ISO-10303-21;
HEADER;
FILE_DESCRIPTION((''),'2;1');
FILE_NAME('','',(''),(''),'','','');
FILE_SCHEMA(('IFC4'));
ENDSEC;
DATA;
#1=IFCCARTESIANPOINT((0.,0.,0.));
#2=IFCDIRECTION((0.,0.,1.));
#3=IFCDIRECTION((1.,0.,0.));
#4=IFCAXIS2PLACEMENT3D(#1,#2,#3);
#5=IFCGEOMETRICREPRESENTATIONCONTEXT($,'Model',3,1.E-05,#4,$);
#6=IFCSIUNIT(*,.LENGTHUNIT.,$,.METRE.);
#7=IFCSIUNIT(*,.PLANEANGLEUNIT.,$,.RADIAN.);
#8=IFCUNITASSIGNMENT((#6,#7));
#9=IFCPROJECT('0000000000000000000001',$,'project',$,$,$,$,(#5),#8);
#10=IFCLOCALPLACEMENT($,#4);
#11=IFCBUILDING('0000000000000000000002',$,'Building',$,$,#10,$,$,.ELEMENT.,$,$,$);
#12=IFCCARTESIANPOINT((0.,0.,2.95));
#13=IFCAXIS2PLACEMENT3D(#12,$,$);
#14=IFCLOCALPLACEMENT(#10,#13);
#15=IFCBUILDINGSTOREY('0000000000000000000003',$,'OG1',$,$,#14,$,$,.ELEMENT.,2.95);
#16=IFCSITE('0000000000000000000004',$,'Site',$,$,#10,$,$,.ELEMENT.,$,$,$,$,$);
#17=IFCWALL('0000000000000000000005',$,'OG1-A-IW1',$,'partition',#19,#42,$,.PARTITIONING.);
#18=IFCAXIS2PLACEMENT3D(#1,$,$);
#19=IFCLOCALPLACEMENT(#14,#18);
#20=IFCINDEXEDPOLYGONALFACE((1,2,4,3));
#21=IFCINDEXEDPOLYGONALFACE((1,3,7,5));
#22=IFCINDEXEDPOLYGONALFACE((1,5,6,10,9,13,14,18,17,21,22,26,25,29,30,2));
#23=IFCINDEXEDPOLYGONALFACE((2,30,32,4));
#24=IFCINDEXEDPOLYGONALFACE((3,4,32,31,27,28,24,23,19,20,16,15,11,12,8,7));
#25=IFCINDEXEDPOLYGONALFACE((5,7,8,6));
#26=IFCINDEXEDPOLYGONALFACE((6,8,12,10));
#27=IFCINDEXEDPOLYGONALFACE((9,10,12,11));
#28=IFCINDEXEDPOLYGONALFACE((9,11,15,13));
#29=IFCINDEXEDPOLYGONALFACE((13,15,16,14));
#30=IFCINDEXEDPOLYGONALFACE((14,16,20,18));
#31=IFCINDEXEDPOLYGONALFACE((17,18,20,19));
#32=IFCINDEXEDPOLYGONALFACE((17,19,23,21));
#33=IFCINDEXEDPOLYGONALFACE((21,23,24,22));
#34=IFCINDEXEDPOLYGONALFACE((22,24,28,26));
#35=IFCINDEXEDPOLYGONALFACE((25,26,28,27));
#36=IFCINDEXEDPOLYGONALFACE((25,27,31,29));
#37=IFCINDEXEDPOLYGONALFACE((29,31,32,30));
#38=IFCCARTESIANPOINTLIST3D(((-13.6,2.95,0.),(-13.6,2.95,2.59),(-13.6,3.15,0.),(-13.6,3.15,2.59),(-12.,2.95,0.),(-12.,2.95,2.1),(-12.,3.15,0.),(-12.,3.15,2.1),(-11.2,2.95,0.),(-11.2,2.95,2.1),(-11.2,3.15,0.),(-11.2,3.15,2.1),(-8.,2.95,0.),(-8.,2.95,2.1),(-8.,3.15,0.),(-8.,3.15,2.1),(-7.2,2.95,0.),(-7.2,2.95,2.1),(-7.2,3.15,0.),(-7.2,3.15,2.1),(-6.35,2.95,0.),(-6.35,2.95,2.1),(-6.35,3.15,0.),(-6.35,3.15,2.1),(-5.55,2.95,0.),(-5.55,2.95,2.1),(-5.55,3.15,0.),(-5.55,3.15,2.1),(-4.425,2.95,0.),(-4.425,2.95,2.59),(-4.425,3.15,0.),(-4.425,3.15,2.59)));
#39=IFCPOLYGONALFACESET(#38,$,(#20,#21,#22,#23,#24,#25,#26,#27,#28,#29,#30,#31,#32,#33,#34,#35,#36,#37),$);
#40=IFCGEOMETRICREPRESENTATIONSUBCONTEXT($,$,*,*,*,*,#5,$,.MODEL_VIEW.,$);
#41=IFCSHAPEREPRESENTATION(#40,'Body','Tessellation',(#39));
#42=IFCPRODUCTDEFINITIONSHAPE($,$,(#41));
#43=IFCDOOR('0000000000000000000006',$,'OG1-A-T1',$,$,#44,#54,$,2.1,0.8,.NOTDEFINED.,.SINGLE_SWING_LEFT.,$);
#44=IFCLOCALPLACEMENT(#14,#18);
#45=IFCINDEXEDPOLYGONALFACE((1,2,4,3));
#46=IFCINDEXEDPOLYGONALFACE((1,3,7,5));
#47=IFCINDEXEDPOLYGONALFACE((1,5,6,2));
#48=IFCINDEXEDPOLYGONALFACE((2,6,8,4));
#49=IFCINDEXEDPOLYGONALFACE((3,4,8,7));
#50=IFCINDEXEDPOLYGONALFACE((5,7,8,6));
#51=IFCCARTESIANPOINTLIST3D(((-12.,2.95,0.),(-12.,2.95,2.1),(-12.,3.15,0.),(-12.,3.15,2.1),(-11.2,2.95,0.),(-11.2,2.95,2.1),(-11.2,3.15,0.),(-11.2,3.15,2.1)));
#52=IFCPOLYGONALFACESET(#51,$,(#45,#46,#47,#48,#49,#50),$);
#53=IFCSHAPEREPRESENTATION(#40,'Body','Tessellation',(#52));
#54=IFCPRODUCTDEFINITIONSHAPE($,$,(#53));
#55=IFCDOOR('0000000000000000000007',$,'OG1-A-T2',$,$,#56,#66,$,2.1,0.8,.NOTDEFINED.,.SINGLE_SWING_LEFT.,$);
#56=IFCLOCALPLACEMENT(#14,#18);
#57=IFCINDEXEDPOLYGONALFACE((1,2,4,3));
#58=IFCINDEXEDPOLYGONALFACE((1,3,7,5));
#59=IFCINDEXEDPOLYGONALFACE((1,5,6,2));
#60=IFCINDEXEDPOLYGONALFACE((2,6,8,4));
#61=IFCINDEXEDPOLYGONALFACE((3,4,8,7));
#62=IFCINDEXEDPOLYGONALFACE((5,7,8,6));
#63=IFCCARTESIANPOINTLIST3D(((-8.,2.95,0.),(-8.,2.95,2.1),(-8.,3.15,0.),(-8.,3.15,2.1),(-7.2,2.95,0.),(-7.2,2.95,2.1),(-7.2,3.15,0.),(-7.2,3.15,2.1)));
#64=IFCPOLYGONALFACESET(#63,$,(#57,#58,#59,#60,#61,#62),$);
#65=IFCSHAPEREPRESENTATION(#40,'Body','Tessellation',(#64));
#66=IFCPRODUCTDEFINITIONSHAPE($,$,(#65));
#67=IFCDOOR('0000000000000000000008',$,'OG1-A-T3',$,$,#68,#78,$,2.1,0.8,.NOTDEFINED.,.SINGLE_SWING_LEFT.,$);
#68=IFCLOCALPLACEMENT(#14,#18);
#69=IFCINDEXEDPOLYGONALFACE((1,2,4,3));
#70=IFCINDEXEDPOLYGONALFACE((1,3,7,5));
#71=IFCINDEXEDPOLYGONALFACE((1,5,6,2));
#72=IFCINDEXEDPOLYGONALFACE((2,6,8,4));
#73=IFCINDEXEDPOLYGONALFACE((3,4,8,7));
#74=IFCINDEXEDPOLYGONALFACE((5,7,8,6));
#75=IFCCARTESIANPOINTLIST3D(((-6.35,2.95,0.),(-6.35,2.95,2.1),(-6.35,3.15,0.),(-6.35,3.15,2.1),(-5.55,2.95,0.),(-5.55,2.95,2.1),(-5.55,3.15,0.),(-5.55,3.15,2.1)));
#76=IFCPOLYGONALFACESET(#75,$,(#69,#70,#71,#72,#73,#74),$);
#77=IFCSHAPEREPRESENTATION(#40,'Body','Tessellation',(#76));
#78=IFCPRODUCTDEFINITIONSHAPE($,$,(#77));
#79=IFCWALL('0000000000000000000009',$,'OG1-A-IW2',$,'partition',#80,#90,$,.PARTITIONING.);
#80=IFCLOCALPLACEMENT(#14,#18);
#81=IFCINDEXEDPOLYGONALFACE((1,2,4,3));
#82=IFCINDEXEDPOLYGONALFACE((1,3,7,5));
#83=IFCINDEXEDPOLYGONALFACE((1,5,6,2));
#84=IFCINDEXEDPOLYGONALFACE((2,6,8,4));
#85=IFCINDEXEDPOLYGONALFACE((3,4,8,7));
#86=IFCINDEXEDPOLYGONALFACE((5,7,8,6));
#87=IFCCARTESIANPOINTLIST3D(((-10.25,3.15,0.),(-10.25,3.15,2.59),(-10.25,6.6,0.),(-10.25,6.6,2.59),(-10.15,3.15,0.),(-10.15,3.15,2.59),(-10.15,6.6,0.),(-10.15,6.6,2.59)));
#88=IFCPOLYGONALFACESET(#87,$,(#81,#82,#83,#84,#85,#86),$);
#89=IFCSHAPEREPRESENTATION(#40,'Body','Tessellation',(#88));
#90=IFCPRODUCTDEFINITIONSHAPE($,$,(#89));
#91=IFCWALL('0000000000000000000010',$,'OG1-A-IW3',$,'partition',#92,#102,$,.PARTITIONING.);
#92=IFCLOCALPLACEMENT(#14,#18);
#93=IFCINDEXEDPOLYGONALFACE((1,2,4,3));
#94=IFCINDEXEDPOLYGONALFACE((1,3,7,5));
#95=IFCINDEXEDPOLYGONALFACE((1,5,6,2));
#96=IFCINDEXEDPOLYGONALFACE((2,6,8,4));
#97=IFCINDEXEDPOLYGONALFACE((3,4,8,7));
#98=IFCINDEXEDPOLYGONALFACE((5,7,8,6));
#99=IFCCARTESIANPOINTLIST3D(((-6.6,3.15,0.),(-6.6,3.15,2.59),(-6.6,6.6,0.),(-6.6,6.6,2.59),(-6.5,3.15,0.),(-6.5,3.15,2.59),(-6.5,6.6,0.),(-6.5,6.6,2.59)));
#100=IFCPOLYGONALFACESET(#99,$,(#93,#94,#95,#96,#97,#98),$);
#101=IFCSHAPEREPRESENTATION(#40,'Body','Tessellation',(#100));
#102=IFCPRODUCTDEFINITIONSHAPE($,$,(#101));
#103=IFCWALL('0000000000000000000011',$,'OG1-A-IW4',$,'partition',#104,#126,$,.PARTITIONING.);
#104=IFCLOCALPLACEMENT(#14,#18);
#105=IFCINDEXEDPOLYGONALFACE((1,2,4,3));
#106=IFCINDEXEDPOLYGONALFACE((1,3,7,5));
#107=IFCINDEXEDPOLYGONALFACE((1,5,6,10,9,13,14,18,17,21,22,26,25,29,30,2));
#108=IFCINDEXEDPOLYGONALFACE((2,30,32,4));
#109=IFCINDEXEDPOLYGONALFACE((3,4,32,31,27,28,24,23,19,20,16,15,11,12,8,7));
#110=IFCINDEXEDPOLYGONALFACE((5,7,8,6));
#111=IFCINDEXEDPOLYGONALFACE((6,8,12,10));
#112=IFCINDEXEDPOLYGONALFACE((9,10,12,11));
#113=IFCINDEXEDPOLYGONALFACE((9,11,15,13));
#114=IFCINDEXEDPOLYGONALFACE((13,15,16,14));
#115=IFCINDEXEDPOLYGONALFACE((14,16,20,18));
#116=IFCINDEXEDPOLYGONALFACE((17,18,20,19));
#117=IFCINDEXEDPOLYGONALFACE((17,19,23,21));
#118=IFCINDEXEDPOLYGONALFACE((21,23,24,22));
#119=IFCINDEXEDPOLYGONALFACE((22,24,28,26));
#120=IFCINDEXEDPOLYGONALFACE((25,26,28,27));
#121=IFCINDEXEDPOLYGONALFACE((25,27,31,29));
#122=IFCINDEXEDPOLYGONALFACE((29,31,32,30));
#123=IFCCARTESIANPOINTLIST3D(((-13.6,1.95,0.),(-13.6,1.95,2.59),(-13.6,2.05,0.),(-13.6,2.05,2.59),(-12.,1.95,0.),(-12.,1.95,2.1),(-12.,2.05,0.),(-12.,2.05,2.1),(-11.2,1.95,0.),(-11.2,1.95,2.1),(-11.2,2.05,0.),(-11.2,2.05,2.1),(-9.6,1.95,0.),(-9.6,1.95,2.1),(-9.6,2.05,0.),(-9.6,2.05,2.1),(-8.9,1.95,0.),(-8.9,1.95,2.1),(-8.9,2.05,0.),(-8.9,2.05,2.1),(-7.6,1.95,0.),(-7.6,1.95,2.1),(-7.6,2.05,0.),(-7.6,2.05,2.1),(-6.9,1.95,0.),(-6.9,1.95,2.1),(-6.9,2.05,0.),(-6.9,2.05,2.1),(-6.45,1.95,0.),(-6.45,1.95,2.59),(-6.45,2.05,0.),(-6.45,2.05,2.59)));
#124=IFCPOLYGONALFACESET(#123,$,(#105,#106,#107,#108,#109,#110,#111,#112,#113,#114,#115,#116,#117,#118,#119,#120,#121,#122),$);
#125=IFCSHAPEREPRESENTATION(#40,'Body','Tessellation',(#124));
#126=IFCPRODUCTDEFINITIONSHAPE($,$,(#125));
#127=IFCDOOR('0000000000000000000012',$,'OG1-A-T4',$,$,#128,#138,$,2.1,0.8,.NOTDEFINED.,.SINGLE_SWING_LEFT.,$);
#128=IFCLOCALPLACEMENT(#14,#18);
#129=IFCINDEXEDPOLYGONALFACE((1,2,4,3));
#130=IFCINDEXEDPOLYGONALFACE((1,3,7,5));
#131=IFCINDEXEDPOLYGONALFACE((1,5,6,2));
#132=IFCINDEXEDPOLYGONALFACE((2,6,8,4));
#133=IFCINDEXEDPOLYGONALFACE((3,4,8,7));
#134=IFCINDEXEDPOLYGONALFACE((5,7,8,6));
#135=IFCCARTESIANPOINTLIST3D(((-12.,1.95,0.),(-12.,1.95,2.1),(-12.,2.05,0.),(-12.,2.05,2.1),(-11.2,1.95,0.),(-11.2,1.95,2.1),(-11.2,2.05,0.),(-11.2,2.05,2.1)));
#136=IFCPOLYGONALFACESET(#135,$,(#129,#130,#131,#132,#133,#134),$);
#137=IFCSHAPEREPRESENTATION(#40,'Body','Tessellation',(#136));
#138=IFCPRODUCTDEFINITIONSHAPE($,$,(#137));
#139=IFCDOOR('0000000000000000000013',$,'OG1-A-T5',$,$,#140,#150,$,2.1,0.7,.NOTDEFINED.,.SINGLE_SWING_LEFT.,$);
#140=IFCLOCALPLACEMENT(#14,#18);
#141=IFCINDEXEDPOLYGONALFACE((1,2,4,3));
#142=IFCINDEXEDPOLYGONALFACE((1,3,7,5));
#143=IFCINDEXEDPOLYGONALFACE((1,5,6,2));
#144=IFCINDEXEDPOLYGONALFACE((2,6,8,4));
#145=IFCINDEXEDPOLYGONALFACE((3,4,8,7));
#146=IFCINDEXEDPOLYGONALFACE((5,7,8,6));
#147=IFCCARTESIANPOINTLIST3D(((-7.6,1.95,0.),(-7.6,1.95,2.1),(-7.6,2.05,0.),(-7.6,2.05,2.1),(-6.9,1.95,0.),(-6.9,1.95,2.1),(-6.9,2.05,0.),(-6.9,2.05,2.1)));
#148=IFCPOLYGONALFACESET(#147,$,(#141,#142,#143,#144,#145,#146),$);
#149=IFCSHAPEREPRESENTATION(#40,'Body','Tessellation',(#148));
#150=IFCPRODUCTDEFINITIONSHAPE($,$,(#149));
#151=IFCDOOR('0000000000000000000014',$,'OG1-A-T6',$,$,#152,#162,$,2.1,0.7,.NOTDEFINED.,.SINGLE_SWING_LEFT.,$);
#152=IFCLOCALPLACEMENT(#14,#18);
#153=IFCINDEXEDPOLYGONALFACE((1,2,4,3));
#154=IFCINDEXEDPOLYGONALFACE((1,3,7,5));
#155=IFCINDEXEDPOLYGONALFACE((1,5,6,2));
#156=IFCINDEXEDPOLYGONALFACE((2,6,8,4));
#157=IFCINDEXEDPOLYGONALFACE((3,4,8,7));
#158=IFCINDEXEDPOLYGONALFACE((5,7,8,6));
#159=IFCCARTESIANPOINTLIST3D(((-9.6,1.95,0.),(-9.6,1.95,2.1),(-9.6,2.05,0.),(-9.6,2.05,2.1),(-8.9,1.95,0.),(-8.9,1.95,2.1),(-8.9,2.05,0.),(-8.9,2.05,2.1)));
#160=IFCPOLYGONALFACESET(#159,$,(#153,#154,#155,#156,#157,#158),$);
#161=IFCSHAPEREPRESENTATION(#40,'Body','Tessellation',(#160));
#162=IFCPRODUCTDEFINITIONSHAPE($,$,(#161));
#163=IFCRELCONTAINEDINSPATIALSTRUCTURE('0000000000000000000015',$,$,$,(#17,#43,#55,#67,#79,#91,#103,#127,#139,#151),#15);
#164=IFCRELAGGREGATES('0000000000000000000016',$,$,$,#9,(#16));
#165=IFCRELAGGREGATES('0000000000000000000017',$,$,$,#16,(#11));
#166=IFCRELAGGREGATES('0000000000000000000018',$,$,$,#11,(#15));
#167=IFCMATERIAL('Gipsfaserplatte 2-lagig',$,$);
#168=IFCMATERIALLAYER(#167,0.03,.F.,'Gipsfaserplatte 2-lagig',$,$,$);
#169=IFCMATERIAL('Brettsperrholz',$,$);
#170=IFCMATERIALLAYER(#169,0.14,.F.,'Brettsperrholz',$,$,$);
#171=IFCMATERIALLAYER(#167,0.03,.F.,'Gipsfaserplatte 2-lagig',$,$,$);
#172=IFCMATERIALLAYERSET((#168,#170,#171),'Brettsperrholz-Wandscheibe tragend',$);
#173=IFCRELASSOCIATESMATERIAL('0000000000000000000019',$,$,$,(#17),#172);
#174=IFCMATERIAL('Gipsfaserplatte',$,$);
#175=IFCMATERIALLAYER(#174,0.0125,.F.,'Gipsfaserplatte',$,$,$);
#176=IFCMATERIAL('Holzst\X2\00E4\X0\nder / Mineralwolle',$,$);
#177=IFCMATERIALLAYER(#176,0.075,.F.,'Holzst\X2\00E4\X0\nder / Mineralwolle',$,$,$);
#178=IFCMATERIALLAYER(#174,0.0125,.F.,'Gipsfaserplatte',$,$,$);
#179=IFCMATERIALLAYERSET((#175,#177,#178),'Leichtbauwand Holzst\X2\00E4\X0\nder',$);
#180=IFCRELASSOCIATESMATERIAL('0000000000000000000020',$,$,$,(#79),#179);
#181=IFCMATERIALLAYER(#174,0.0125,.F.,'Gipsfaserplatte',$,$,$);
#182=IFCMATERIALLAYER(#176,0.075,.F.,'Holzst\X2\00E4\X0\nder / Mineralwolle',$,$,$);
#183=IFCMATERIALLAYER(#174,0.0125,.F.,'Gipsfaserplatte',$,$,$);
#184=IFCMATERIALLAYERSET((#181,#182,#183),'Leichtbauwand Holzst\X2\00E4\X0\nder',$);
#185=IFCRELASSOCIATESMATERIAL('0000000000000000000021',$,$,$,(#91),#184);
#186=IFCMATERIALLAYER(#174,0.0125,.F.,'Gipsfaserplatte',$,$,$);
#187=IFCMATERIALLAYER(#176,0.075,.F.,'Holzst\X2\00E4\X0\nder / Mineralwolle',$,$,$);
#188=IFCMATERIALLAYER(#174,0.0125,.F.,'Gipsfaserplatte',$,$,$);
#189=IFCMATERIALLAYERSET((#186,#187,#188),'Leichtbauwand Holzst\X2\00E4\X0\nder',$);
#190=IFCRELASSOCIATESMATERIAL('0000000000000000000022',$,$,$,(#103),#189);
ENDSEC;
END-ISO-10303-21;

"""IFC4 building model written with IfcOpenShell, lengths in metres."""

from ifc_helpers import new_model, si_unit, frame, frame_2d, origin, origin_with_axes, place, context, subcontext, project, spatial, rectangle, extrude, material, layer, layer_set, element, fill, save


model = new_model("IFC4")

# Units and contexts
model_context = context("Model", 3, precision=1e-05, world=origin_with_axes())
sub_context = subcontext(model_context, None, None, "MODEL_VIEW")
ifc_project = project(units=[si_unit("LENGTHUNIT", "METRE"), si_unit("PLANEANGLEUNIT", "RADIAN")], contexts=[model_context])

# Site, building, storey
placement = place(None, origin_with_axes())
site = spatial("IfcSite", under=ifc_project, at=placement, Name="Site", CompositionType="ELEMENT")
building = spatial("IfcBuilding", under=site, at=placement, Name="Building", CompositionType="ELEMENT")
storey_placement = place(placement, frame((0.0, 0.0, 2.95)))
storey = spatial("IfcBuildingStorey", under=building, at=storey_placement, Name="OG1", CompositionType="ELEMENT", Elevation=2.95)

# Shared definitions
ifc_material_1 = material(Name="Gipsfaserplatte")

# Wall, openings, doors
ifc_material_2 = material(Name="Gipsfaserplatte 2-lagig")
ifc_layer_1 = layer(ifc_material_2, 0.03, ventilated=False, Name="Gipsfaserplatte 2-lagig")
ifc_material_3 = material(Name="Brettsperrholz")
ifc_layer_2 = layer(ifc_material_3, 0.14, ventilated=False, Name="Brettsperrholz")
ifc_layer_3 = layer(ifc_material_2, 0.03, ventilated=False, Name="Gipsfaserplatte 2-lagig")
ifc_layer_set_1 = layer_set([ifc_layer_1, ifc_layer_2, ifc_layer_3], Name="Brettsperrholz-Wandscheibe tragend")
wall_1_placement = place(storey_placement, frame((-13.6, 3.05, 0.0), z_axis=(0.0, 0.0, 1.0), x_axis=(1.0, 0.0, 0.0)))
wall_1 = element("IfcWall", 1, at=wall_1_placement, inside=storey, material=ifc_layer_set_1, Name="OG1-A-IW1", ObjectType="partition", PredefinedType="PARTITIONING", context=sub_context, shape_type="SweptSolid", body=[
    extrude(rectangle(XDim=9.175, YDim=0.2, at=frame_2d((4.5875, 0.0))), origin(), (0.0, 0.0, 1.0), 2.59),
])
opening_1_placement = place(wall_1_placement, frame((2.0, 0.15, 0.0), z_axis=(0.0, -1.0, 0.0), x_axis=(1.0, 0.0, 0.0)))
opening_1 = element("IfcOpeningElement", 2, at=opening_1_placement, cuts=wall_1, PredefinedType="OPENING", context=sub_context, shape_type="SweptSolid", body=[
    extrude(rectangle(XDim=0.8, YDim=2.1, at=frame_2d((0.0, 1.05))), origin(), (0.0, 0.0, 1.0), 0.3),
])
opening_2_placement = place(wall_1_placement, frame((6.0, 0.15, 0.0), z_axis=(0.0, -1.0, 0.0), x_axis=(1.0, 0.0, 0.0)))
opening_2 = element("IfcOpeningElement", 3, at=opening_2_placement, cuts=wall_1, PredefinedType="OPENING", context=sub_context, shape_type="SweptSolid", body=[
    extrude(rectangle(XDim=0.8, YDim=2.1, at=frame_2d((0.0, 1.05))), origin(), (0.0, 0.0, 1.0), 0.3),
])
opening_3_placement = place(wall_1_placement, frame((7.65, 0.15, 0.0), z_axis=(0.0, -1.0, 0.0), x_axis=(1.0, 0.0, 0.0)))
opening_3 = element("IfcOpeningElement", 4, at=opening_3_placement, cuts=wall_1, PredefinedType="OPENING", context=sub_context, shape_type="SweptSolid", body=[
    extrude(rectangle(XDim=0.8, YDim=2.1, at=frame_2d((0.0, 1.05))), origin(), (0.0, 0.0, 1.0), 0.3),
])
door_1_placement = place(wall_1_placement, frame((2.0, 0.1, 0.0), z_axis=(0.0, -1.0, 0.0), x_axis=(1.0, 0.0, 0.0)))
door_1 = element("IfcDoor", 5, at=door_1_placement, inside=storey, Name="OG1-A-T1", OperationType="SINGLE_SWING_LEFT", OverallHeight=2.1, OverallWidth=0.8, PredefinedType="NOTDEFINED", context=sub_context, shape_type="SweptSolid", body=[
    extrude(rectangle(XDim=0.8, YDim=2.1, at=frame_2d((0.0, 1.05))), origin(), (0.0, 0.0, 1.0), 0.2),
])
fill(opening_1, door_1)
door_2_placement = place(wall_1_placement, frame((6.0, 0.1, 0.0), z_axis=(0.0, -1.0, 0.0), x_axis=(1.0, 0.0, 0.0)))
door_2 = element("IfcDoor", 6, at=door_2_placement, inside=storey, Name="OG1-A-T2", OperationType="SINGLE_SWING_LEFT", OverallHeight=2.1, OverallWidth=0.8, PredefinedType="NOTDEFINED", context=sub_context, shape_type="SweptSolid", body=[
    extrude(rectangle(XDim=0.8, YDim=2.1, at=frame_2d((0.0, 1.05))), origin(), (0.0, 0.0, 1.0), 0.2),
])
fill(opening_2, door_2)
door_3_placement = place(wall_1_placement, frame((7.65, 0.1, 0.0), z_axis=(0.0, -1.0, 0.0), x_axis=(1.0, 0.0, 0.0)))
door_3 = element("IfcDoor", 7, at=door_3_placement, inside=storey, Name="OG1-A-T3", OperationType="SINGLE_SWING_LEFT", OverallHeight=2.1, OverallWidth=0.8, PredefinedType="NOTDEFINED", context=sub_context, shape_type="SweptSolid", body=[
    extrude(rectangle(XDim=0.8, YDim=2.1, at=frame_2d((0.0, 1.05))), origin(), (0.0, 0.0, 1.0), 0.2),
])
fill(opening_3, door_3)

# Walls
ifc_layer_4 = layer(ifc_material_1, 0.0125, ventilated=False, Name="Gipsfaserplatte")
ifc_material_4 = material(Name="Holzständer / Mineralwolle")
ifc_layer_5 = layer(ifc_material_4, 0.075, ventilated=False, Name="Holzständer / Mineralwolle")
ifc_layer_6 = layer(ifc_material_1, 0.0125, ventilated=False, Name="Gipsfaserplatte")
ifc_layer_set_2 = layer_set([ifc_layer_4, ifc_layer_5, ifc_layer_6], Name="Leichtbauwand Holzständer")
wall_2_placement = place(storey_placement, frame((-10.2, 3.15, 0.0), z_axis=(0.0, 0.0, 1.0), x_axis=(0.0, 1.0, 0.0)))
element("IfcWall", 8, at=wall_2_placement, inside=storey, material=ifc_layer_set_2, Name="OG1-A-IW2", ObjectType="partition", PredefinedType="PARTITIONING", context=sub_context, shape_type="SweptSolid", body=[
    extrude(rectangle(XDim=3.45, YDim=0.1, at=frame_2d((1.725, 0.0))), origin(), (0.0, 0.0, 1.0), 2.59),
])
ifc_layer_7 = layer(ifc_material_1, 0.0125, ventilated=False, Name="Gipsfaserplatte")
ifc_layer_8 = layer(ifc_material_4, 0.075, ventilated=False, Name="Holzständer / Mineralwolle")
ifc_layer_9 = layer(ifc_material_1, 0.0125, ventilated=False, Name="Gipsfaserplatte")
ifc_layer_set_3 = layer_set([ifc_layer_7, ifc_layer_8, ifc_layer_9], Name="Leichtbauwand Holzständer")
wall_3_placement = place(storey_placement, frame((-6.55, 3.15, 0.0), z_axis=(0.0, 0.0, 1.0), x_axis=(0.0, 1.0, 0.0)))
element("IfcWall", 9, at=wall_3_placement, inside=storey, material=ifc_layer_set_3, Name="OG1-A-IW3", ObjectType="partition", PredefinedType="PARTITIONING", context=sub_context, shape_type="SweptSolid", body=[
    extrude(rectangle(XDim=3.45, YDim=0.1, at=frame_2d((1.725, 0.0))), origin(), (0.0, 0.0, 1.0), 2.59),
])

# Wall, openings, doors
ifc_layer_10 = layer(ifc_material_1, 0.0125, ventilated=False, Name="Gipsfaserplatte")
ifc_layer_11 = layer(ifc_material_4, 0.075, ventilated=False, Name="Holzständer / Mineralwolle")
ifc_layer_12 = layer(ifc_material_1, 0.0125, ventilated=False, Name="Gipsfaserplatte")
ifc_layer_set_4 = layer_set([ifc_layer_10, ifc_layer_11, ifc_layer_12], Name="Leichtbauwand Holzständer")
wall_4_placement = place(storey_placement, frame((-13.6, 2.0, 0.0), z_axis=(0.0, 0.0, 1.0), x_axis=(1.0, 0.0, 0.0)))
wall_4 = element("IfcWall", 10, at=wall_4_placement, inside=storey, material=ifc_layer_set_4, Name="OG1-A-IW4", ObjectType="partition", PredefinedType="PARTITIONING", context=sub_context, shape_type="SweptSolid", body=[
    extrude(rectangle(XDim=7.15, YDim=0.1, at=frame_2d((3.575, 0.0))), origin(), (0.0, 0.0, 1.0), 2.59),
])
opening_4_placement = place(wall_4_placement, frame((2.0, 0.1, 0.0), z_axis=(0.0, -1.0, 0.0), x_axis=(1.0, 0.0, 0.0)))
opening_4 = element("IfcOpeningElement", 11, at=opening_4_placement, cuts=wall_4, PredefinedType="OPENING", context=sub_context, shape_type="SweptSolid", body=[
    extrude(rectangle(XDim=0.8, YDim=2.1, at=frame_2d((0.0, 1.05))), origin(), (0.0, 0.0, 1.0), 0.2),
])
opening_5_placement = place(wall_4_placement, frame((6.35, 0.1, 0.0), z_axis=(0.0, -1.0, 0.0), x_axis=(1.0, 0.0, 0.0)))
opening_5 = element("IfcOpeningElement", 12, at=opening_5_placement, cuts=wall_4, PredefinedType="OPENING", context=sub_context, shape_type="SweptSolid", body=[
    extrude(rectangle(XDim=0.7, YDim=2.1, at=frame_2d((0.0, 1.05))), origin(), (0.0, 0.0, 1.0), 0.2),
])
opening_6_placement = place(wall_4_placement, frame((4.35, 0.1, 0.0), z_axis=(0.0, -1.0, 0.0), x_axis=(1.0, 0.0, 0.0)))
opening_6 = element("IfcOpeningElement", 13, at=opening_6_placement, cuts=wall_4, PredefinedType="OPENING", context=sub_context, shape_type="SweptSolid", body=[
    extrude(rectangle(XDim=0.7, YDim=2.1, at=frame_2d((0.0, 1.05))), origin(), (0.0, 0.0, 1.0), 0.2),
])
door_4_placement = place(wall_4_placement, frame((2.0, 0.05, 0.0), z_axis=(0.0, -1.0, 0.0), x_axis=(1.0, 0.0, 0.0)))
door_4 = element("IfcDoor", 14, at=door_4_placement, inside=storey, Name="OG1-A-T4", OperationType="SINGLE_SWING_LEFT", OverallHeight=2.1, OverallWidth=0.8, PredefinedType="NOTDEFINED", context=sub_context, shape_type="SweptSolid", body=[
    extrude(rectangle(XDim=0.8, YDim=2.1, at=frame_2d((0.0, 1.05))), origin(), (0.0, 0.0, 1.0), 0.1),
])
fill(opening_4, door_4)
door_5_placement = place(wall_4_placement, frame((6.35, 0.05, 0.0), z_axis=(0.0, -1.0, 0.0), x_axis=(1.0, 0.0, 0.0)))
door_5 = element("IfcDoor", 15, at=door_5_placement, inside=storey, Name="OG1-A-T5", OperationType="SINGLE_SWING_LEFT", OverallHeight=2.1, OverallWidth=0.7, PredefinedType="NOTDEFINED", context=sub_context, shape_type="SweptSolid", body=[
    extrude(rectangle(XDim=0.7, YDim=2.1, at=frame_2d((0.0, 1.05))), origin(), (0.0, 0.0, 1.0), 0.1),
])
fill(opening_5, door_5)
door_6_placement = place(wall_4_placement, frame((4.35, 0.05, 0.0), z_axis=(0.0, -1.0, 0.0), x_axis=(1.0, 0.0, 0.0)))
door_6 = element("IfcDoor", 16, at=door_6_placement, inside=storey, Name="OG1-A-T6", OperationType="SINGLE_SWING_LEFT", OverallHeight=2.1, OverallWidth=0.7, PredefinedType="NOTDEFINED", context=sub_context, shape_type="SweptSolid", body=[
    extrude(rectangle(XDim=0.7, YDim=2.1, at=frame_2d((0.0, 1.05))), origin(), (0.0, 0.0, 1.0), 0.1),
])
fill(opening_6, door_6)

save(model, "model.ifc")
